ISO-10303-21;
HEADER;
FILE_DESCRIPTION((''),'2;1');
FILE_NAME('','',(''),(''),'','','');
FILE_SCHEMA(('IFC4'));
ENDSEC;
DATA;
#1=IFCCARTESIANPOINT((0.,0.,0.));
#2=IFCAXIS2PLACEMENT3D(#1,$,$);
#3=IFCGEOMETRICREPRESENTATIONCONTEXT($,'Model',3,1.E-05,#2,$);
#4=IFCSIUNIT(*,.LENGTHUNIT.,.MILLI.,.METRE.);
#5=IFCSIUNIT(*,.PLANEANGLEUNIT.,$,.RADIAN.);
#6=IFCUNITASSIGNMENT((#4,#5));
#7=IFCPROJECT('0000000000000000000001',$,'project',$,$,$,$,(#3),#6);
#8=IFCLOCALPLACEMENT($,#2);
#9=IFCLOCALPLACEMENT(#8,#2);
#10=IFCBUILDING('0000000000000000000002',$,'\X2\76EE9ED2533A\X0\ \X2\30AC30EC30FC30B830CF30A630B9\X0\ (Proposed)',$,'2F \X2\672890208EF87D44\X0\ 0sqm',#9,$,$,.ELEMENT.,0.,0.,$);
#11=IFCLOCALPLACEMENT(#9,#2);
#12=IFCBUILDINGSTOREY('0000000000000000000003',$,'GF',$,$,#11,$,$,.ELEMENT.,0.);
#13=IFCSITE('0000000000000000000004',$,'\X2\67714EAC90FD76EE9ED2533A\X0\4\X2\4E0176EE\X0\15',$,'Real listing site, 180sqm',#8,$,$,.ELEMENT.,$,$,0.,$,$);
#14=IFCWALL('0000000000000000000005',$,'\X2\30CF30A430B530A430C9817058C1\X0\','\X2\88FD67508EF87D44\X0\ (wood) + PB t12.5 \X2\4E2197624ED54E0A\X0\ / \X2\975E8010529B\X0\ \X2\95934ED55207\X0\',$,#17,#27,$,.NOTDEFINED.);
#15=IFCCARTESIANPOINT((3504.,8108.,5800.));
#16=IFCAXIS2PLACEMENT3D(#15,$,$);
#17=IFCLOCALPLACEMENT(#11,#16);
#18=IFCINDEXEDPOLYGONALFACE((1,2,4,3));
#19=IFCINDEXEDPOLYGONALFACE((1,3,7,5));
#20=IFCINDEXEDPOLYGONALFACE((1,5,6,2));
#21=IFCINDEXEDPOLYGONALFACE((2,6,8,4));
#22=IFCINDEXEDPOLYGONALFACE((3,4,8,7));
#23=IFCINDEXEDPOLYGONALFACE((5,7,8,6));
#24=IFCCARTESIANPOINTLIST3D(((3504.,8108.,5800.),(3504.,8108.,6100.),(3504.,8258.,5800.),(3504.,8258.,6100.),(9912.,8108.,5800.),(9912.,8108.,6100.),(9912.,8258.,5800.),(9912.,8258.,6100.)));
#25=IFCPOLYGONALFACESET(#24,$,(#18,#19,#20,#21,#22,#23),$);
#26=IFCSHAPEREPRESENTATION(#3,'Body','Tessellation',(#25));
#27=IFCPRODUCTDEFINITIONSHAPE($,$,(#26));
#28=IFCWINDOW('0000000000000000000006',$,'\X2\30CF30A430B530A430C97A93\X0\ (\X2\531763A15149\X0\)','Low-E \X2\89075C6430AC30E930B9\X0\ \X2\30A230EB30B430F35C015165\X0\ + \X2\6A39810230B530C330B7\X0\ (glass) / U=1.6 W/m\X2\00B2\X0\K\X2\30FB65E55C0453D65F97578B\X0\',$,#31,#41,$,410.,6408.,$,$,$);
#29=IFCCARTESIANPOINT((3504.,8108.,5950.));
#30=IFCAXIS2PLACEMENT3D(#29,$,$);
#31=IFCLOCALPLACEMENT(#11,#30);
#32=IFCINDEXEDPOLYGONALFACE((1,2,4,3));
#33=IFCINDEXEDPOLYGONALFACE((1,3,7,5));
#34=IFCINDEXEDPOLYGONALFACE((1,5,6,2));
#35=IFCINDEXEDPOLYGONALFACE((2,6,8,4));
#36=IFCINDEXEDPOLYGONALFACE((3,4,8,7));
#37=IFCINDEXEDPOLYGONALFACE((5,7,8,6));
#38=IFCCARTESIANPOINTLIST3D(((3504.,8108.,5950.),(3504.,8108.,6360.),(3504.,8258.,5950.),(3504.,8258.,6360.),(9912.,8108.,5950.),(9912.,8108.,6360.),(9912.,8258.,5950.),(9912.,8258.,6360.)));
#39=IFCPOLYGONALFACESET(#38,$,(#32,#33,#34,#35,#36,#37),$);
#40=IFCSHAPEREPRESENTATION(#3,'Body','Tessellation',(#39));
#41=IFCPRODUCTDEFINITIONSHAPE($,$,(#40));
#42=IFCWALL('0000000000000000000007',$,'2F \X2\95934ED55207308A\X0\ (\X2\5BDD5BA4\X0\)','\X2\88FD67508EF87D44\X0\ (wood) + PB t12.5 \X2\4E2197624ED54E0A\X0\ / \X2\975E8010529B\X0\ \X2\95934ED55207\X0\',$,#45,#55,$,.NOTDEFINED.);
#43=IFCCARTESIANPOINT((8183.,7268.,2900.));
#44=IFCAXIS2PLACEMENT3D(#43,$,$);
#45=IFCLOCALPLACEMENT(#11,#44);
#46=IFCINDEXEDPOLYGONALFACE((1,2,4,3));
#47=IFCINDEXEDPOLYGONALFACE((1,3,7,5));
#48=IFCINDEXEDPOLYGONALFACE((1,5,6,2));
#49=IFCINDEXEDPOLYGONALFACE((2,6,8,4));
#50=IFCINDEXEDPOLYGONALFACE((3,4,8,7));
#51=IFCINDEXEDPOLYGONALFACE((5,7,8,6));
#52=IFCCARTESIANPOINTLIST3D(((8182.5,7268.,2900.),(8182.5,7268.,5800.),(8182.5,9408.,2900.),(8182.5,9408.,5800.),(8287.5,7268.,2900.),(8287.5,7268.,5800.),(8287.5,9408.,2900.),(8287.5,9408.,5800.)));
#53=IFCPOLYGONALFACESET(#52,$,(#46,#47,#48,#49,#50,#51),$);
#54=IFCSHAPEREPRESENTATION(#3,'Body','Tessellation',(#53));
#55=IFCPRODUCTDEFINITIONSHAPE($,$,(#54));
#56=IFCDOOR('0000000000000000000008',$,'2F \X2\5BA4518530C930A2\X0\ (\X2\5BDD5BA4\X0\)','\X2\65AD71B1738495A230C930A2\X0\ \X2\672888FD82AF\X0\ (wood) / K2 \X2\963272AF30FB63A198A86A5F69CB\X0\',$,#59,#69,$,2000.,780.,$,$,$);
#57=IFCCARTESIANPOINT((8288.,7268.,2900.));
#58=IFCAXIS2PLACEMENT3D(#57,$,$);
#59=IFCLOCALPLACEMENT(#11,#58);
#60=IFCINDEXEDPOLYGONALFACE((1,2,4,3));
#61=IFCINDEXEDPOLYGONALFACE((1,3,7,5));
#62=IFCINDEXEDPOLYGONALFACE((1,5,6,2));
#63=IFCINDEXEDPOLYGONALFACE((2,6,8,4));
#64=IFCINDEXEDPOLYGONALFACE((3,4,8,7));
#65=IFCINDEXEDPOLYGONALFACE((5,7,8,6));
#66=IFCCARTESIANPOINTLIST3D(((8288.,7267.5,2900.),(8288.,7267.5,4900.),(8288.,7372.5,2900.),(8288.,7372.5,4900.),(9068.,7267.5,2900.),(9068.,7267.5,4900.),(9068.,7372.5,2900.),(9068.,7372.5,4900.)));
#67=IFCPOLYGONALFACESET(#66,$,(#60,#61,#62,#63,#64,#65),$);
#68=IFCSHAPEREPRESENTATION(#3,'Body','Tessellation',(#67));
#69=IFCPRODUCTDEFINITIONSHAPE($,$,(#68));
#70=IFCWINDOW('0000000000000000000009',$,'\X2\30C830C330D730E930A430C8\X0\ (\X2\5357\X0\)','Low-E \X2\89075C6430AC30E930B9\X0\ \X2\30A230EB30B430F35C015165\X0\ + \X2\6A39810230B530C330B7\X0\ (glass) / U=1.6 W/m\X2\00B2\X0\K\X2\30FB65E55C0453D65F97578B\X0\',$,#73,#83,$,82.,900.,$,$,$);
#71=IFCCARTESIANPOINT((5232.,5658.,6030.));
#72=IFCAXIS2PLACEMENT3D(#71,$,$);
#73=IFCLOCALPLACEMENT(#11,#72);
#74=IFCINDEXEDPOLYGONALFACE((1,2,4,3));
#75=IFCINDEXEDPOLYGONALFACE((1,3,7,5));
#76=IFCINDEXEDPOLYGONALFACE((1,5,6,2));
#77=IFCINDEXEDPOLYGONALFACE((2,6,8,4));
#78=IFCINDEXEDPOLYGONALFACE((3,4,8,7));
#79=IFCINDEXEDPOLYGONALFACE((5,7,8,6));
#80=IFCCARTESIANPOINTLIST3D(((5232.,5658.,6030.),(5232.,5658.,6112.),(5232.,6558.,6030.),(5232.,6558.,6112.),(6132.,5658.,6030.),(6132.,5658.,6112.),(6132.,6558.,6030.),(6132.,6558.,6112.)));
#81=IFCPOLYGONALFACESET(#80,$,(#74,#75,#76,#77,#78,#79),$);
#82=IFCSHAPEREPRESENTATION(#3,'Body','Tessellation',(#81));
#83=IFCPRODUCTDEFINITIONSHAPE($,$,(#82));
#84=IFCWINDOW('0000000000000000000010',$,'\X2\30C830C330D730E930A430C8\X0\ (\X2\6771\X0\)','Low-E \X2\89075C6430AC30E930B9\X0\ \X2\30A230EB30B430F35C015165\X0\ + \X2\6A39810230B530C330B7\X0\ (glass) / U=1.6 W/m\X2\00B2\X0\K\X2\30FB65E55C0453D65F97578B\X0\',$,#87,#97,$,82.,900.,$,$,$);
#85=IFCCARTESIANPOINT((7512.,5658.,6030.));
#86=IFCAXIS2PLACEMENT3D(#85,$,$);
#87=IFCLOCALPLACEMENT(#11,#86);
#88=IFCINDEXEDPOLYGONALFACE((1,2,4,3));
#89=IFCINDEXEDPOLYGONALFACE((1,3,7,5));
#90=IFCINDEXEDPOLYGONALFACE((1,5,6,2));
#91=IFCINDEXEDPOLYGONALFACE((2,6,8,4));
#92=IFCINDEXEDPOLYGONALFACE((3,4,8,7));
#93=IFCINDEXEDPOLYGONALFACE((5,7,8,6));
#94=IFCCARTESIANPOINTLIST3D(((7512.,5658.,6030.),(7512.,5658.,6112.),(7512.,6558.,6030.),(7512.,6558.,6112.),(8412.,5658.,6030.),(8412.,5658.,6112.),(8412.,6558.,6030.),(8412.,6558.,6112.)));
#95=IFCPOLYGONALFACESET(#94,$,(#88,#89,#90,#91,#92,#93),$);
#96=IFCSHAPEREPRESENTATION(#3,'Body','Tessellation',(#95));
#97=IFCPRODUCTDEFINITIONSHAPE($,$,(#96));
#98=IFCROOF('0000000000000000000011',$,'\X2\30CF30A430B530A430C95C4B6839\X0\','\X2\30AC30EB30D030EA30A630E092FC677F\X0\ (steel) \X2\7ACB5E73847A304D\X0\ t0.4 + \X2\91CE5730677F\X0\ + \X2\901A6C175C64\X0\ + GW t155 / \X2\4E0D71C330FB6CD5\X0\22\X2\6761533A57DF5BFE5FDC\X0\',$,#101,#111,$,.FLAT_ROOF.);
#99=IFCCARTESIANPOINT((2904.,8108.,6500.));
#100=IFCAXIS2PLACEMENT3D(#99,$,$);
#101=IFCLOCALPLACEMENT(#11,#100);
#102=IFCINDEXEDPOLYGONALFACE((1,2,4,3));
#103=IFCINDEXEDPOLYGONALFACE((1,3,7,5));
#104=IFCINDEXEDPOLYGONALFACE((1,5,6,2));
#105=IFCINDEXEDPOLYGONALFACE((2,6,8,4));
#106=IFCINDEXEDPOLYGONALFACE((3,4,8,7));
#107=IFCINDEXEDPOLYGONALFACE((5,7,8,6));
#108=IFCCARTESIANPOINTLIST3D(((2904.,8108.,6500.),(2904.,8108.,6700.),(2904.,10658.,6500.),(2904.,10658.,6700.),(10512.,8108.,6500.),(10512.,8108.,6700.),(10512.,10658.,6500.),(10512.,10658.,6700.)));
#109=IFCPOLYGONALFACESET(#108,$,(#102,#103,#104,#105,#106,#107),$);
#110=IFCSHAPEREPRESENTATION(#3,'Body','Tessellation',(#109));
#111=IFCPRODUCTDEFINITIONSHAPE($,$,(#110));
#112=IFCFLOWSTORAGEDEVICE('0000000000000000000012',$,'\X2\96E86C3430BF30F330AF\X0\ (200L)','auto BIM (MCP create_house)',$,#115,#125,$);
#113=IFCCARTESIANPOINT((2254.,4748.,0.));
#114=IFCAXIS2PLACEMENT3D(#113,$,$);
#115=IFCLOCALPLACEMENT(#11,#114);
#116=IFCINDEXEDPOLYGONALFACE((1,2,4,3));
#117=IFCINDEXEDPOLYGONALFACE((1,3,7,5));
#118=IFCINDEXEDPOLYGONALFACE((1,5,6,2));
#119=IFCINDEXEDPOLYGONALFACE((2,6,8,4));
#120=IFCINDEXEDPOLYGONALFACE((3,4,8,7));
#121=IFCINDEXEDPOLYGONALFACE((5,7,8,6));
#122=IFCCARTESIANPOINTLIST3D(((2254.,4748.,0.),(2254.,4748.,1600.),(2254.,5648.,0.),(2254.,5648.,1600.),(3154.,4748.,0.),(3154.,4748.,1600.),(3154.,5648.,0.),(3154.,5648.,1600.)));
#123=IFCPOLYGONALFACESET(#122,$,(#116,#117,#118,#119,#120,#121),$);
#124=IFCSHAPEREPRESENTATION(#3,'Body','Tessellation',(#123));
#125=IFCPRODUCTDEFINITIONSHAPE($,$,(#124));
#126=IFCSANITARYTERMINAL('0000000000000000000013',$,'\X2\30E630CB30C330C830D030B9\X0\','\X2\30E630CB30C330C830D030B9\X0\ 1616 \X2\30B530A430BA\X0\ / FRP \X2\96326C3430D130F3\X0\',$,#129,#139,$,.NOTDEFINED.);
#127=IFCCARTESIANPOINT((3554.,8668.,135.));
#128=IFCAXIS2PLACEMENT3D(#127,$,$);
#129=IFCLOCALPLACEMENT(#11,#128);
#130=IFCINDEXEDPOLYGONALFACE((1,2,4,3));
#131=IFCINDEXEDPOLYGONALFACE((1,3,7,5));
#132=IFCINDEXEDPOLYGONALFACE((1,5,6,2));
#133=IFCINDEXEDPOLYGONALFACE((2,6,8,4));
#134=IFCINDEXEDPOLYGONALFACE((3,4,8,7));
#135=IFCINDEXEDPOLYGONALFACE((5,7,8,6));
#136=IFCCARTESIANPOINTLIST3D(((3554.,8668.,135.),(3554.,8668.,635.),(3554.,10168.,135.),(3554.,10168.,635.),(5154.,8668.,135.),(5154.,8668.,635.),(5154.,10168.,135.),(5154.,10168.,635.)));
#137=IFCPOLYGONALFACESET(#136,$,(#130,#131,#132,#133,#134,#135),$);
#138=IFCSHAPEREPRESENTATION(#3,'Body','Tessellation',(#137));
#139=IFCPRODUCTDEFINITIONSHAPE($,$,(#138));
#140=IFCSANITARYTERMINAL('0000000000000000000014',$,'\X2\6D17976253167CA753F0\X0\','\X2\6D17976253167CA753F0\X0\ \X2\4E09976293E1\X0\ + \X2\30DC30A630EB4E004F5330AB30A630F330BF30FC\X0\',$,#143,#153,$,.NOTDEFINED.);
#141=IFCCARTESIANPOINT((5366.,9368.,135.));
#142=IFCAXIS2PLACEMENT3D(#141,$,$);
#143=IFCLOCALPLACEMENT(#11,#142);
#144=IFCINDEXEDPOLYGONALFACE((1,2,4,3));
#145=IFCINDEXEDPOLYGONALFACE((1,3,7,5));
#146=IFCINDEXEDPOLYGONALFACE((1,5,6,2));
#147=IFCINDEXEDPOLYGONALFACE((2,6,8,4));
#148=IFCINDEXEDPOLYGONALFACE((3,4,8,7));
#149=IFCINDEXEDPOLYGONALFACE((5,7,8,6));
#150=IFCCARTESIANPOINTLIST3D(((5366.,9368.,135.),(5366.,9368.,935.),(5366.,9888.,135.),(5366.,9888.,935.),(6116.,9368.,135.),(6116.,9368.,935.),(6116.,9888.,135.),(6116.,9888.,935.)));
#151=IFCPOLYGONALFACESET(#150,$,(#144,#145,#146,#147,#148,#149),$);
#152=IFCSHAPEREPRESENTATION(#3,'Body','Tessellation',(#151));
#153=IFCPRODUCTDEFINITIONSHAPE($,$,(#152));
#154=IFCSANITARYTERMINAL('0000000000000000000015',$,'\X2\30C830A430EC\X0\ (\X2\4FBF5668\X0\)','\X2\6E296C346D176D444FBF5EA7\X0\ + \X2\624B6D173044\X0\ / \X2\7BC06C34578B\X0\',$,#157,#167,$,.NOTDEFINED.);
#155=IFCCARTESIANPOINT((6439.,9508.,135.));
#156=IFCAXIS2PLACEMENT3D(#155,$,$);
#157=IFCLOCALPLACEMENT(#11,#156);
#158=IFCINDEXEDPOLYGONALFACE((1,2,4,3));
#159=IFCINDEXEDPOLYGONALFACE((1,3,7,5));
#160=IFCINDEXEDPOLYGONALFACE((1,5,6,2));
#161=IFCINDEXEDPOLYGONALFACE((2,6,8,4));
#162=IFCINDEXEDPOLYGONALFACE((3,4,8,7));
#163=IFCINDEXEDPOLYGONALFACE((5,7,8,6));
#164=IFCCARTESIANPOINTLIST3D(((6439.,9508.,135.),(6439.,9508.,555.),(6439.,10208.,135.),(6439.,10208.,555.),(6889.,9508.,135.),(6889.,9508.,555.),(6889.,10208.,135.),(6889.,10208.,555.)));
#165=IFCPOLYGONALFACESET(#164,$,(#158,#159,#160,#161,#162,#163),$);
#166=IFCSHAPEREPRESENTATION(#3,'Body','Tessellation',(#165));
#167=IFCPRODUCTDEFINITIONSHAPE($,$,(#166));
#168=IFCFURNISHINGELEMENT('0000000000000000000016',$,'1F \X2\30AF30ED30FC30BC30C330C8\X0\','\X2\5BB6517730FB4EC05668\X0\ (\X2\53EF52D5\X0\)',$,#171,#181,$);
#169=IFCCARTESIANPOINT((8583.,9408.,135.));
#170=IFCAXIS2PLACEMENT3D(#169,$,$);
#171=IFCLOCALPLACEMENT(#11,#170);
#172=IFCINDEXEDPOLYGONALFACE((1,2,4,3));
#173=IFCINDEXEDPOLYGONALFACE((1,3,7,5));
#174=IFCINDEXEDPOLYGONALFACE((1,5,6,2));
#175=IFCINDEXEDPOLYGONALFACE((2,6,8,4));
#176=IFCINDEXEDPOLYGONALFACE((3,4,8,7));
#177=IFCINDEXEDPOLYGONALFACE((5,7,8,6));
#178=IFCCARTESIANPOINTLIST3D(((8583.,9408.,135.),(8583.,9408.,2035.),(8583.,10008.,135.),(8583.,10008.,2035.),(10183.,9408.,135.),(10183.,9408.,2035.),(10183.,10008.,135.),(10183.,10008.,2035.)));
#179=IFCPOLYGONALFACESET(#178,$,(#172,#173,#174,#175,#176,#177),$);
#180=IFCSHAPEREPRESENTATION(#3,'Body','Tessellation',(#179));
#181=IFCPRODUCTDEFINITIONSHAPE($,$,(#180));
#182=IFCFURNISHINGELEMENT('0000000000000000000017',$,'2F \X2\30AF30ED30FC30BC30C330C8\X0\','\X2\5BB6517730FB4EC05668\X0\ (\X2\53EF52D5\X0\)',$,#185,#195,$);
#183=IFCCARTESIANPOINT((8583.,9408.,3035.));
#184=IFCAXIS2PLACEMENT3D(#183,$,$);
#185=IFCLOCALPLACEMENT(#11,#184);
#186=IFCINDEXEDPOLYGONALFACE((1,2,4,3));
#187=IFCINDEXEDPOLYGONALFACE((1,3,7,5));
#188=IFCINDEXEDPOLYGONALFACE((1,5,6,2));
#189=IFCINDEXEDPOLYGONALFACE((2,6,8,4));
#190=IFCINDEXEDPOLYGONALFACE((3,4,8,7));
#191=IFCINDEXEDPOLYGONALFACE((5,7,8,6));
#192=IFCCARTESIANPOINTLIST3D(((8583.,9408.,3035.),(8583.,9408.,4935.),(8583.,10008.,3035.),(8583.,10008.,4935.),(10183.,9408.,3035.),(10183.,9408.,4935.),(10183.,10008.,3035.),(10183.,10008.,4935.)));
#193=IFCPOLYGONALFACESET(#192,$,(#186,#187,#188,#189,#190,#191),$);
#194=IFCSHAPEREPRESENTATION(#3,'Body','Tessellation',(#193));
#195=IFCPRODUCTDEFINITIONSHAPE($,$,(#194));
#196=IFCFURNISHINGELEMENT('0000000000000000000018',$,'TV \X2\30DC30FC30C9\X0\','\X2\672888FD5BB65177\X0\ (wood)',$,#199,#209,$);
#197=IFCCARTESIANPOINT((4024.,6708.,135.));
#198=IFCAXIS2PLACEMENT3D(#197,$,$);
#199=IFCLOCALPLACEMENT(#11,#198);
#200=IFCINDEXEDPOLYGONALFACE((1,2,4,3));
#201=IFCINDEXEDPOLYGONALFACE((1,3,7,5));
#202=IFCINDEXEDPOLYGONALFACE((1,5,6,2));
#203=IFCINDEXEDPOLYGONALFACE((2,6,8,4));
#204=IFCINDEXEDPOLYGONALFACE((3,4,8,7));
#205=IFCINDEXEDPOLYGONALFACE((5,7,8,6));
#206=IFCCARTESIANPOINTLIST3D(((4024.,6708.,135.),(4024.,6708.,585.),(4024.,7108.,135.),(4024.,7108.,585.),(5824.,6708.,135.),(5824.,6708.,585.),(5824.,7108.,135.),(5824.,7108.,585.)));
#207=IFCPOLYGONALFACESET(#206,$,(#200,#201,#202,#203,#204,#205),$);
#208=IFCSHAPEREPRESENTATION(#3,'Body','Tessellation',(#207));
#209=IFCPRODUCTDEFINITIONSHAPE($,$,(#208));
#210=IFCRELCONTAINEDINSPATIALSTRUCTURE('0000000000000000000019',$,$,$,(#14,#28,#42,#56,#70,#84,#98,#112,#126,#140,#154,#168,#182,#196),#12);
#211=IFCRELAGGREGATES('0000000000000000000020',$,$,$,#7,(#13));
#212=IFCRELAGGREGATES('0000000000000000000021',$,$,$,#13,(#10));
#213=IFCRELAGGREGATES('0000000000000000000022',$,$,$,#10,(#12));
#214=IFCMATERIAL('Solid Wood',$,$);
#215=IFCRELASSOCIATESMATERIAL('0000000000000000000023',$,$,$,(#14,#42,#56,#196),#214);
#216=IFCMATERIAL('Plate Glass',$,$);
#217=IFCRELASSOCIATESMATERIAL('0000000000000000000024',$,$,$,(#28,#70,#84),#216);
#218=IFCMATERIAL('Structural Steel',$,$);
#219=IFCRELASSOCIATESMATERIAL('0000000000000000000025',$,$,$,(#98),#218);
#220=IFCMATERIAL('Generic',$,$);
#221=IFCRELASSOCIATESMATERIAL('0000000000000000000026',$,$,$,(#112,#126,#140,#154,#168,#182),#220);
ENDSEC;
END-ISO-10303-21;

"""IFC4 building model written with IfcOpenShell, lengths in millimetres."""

from ifc_helpers import new_model, si_unit, frame, frame_2d, origin, place, context, project, spatial, rectangle, extrude, material, element, fill, save


model = new_model("IFC4")

# Units and contexts
model_context = context("Model", 3, precision=1e-05, world=origin())
ifc_project = project(units=[si_unit("LENGTHUNIT", "METRE", prefix="MILLI"), si_unit("PLANEANGLEUNIT", "RADIAN")], contexts=[model_context])

# Site, building, storey
site_placement = place(None, origin())
site = spatial("IfcSite", under=ifc_project, at=site_placement, Name="東京都目黒区4丁目15", ObjectType="Real listing site, 180sqm", CompositionType="ELEMENT", RefElevation=0.0)
building_placement = place(site_placement, origin())
building = spatial("IfcBuilding", under=site, at=building_placement, Name="目黒区 ガレージハウス (Proposed)", ObjectType="2F 木造軸組 0sqm", CompositionType="ELEMENT", ElevationOfRefHeight=0.0, ElevationOfTerrain=0.0)
storey_placement = place(building_placement, origin())
storey = spatial("IfcBuildingStorey", under=building, at=storey_placement, Name="GF", CompositionType="ELEMENT", Elevation=0.0)

# Shared definitions
ifc_material_1 = material(Name="Solid Wood")
ifc_material_2 = material(Name="Plate Glass")

# Wall, opening, window
wall_1_placement = place(storey_placement, frame((3504.0, 8108.0, 5800.0)))
wall_1 = element("IfcWall", 1, at=wall_1_placement, inside=storey, material=ifc_material_1, Name="ハイサイド腰壁", Description="製材軸組 (wood) + PB t12.5 両面仕上 / 非耐力 間仕切", PredefinedType="NOTDEFINED", context=model_context, shape_type="SweptSolid", body=[
    extrude(rectangle(XDim=6408.0, YDim=150.0, at=frame_2d((3204.0, 75.0))), frame((3504.0, 8108.0, 5800.0)), (0.0, 0.0, 1.0), 700.0),
])
opening_1_placement = place(storey_placement, frame((3504.0, 8108.0, 5950.0)))
opening_1 = element("IfcOpeningElement", 2, at=opening_1_placement, cuts=wall_1, PredefinedType="NOTDEFINED", context=model_context, shape_type="SweptSolid", body=[
    extrude(rectangle(XDim=6408.0, YDim=150.0, at=frame_2d((3204.0, 75.0))), frame((3504.0, 8108.0, 5950.0)), (0.0, 0.0, 1.0), 410.0),
])
window_1_placement = place(storey_placement, frame((3504.0, 8108.0, 5950.0)))
window_1 = element("IfcWindow", 3, at=window_1_placement, inside=storey, material=ifc_material_2, Name="ハイサイド窓 (北採光)", Description="Low-E 複層ガラス アルゴン封入 + 樹脂サッシ (glass) / U=1.6 W/m²K・日射取得型", OverallHeight=410.0, OverallWidth=6408.0, context=model_context, shape_type="SweptSolid", body=[
    extrude(rectangle(XDim=6408.0, YDim=150.0, at=frame_2d((3204.0, 75.0))), frame((3504.0, 8108.0, 5950.0)), (0.0, 0.0, 1.0), 410.0),
])
fill(opening_1, window_1)

# Wall
wall_2_placement = place(storey_placement, frame((8183.0, 7268.0, 2900.0)))
element("IfcWall", 4, at=wall_2_placement, inside=storey, material=ifc_material_1, Name="2F 間仕切り (寝室)", Description="製材軸組 (wood) + PB t12.5 両面仕上 / 非耐力 間仕切", PredefinedType="NOTDEFINED", context=model_context, shape_type="SweptSolid", body=[
    extrude(rectangle(XDim=105.0, YDim=2140.0, at=frame_2d((52.0, 1070.0))), frame((8183.0, 7268.0, 2900.0)), (0.0, 0.0, 1.0), 2900.0),
])

# Door
door_1_placement = place(storey_placement, frame((8288.0, 7268.0, 2900.0)))
element("IfcDoor", 5, at=door_1_placement, inside=storey, material=ifc_material_1, Name="2F 室内ドア (寝室)", Description="断熱玄関ドア 木製芯 (wood) / K2 防犯・採風機構", OverallHeight=2000.0, OverallWidth=780.0, context=model_context, shape_type="SweptSolid", body=[
    extrude(rectangle(XDim=780.0, YDim=105.0, at=frame_2d((390.0, 52.0))), frame((8288.0, 7268.0, 2900.0)), (0.0, 0.0, 1.0), 2000.0),
])

# Windows
window_2_placement = place(storey_placement, frame((5232.0, 5658.0, 6030.0)))
element("IfcWindow", 6, at=window_2_placement, inside=storey, material=ifc_material_2, Name="トップライト (南)", Description="Low-E 複層ガラス アルゴン封入 + 樹脂サッシ (glass) / U=1.6 W/m²K・日射取得型", OverallHeight=82.0, OverallWidth=900.0, context=model_context, shape_type="SweptSolid", body=[
    extrude(rectangle(XDim=900.0, YDim=900.0, at=frame_2d((450.0, 450.0))), frame((5232.0, 5658.0, 6030.0)), (0.0, 0.0, 1.0), 82.0),
])
window_3_placement = place(storey_placement, frame((7512.0, 5658.0, 6030.0)))
element("IfcWindow", 7, at=window_3_placement, inside=storey, material=ifc_material_2, Name="トップライト (東)", Description="Low-E 複層ガラス アルゴン封入 + 樹脂サッシ (glass) / U=1.6 W/m²K・日射取得型", OverallHeight=82.0, OverallWidth=900.0, context=model_context, shape_type="SweptSolid", body=[
    extrude(rectangle(XDim=900.0, YDim=900.0, at=frame_2d((450.0, 450.0))), frame((7512.0, 5658.0, 6030.0)), (0.0, 0.0, 1.0), 82.0),
])

# Roof
ifc_material_3 = material(Name="Structural Steel")
roof_placement = place(storey_placement, frame((2904.0, 8108.0, 6500.0)))
element("IfcRoof", 8, at=roof_placement, inside=storey, material=ifc_material_3, Name="ハイサイド屋根", Description="ガルバリウム鋼板 (steel) 立平葺き t0.4 + 野地板 + 通気層 + GW t155 / 不燃・法22条区域対応", PredefinedType="FLAT_ROOF", context=model_context, shape_type="SweptSolid", body=[
    extrude(rectangle(XDim=7608.0, YDim=2550.0, at=frame_2d((3804.0, 1275.0))), frame((2904.0, 8108.0, 6500.0)), (0.0, 0.0, 1.0), 200.0),
])

# Flow storage device
ifc_material_4 = material(Name="Generic")
flow_storage_device_placement = place(storey_placement, frame((2254.0, 4748.0, 0.0)))
element("IfcFlowStorageDevice", 9, at=flow_storage_device_placement, inside=storey, material=ifc_material_4, Name="雨水タンク (200L)", Description="auto BIM (MCP create_house)", context=model_context, shape_type="SweptSolid", body=[
    extrude(rectangle(XDim=900.0, YDim=900.0, at=frame_2d((450.0, 450.0))), frame((2254.0, 4748.0, 0.0)), (0.0, 0.0, 1.0), 1600.0),
])

# Sanitary terminals
sanitary_terminal_1_placement = place(storey_placement, frame((3554.0, 8668.0, 135.0)))
element("IfcSanitaryTerminal", 10, at=sanitary_terminal_1_placement, inside=storey, material=ifc_material_4, Name="ユニットバス", Description="ユニットバス 1616 サイズ / FRP 防水パン", PredefinedType="NOTDEFINED", context=model_context, shape_type="SweptSolid", body=[
    extrude(rectangle(XDim=1600.0, YDim=1500.0, at=frame_2d((800.0, 750.0))), frame((3554.0, 8668.0, 135.0)), (0.0, 0.0, 1.0), 500.0),
])
sanitary_terminal_2_placement = place(storey_placement, frame((5366.0, 9368.0, 135.0)))
element("IfcSanitaryTerminal", 11, at=sanitary_terminal_2_placement, inside=storey, material=ifc_material_4, Name="洗面化粧台", Description="洗面化粧台 三面鏡 + ボウル一体カウンター", PredefinedType="NOTDEFINED", context=model_context, shape_type="SweptSolid", body=[
    extrude(rectangle(XDim=750.0, YDim=520.0, at=frame_2d((375.0, 260.0))), frame((5366.0, 9368.0, 135.0)), (0.0, 0.0, 1.0), 800.0),
])
sanitary_terminal_3_placement = place(storey_placement, frame((6439.0, 9508.0, 135.0)))
element("IfcSanitaryTerminal", 12, at=sanitary_terminal_3_placement, inside=storey, material=ifc_material_4, Name="トイレ (便器)", Description="温水洗浄便座 + 手洗い / 節水型", PredefinedType="NOTDEFINED", context=model_context, shape_type="SweptSolid", body=[
    extrude(rectangle(XDim=450.0, YDim=700.0, at=frame_2d((225.0, 350.0))), frame((6439.0, 9508.0, 135.0)), (0.0, 0.0, 1.0), 420.0),
])

# Furnishing elements
furnishing_1_placement = place(storey_placement, frame((8583.0, 9408.0, 135.0)))
element("IfcFurnishingElement", 13, at=furnishing_1_placement, inside=storey, material=ifc_material_4, Name="1F クローゼット", Description="家具・什器 (可動)", context=model_context, shape_type="SweptSolid", body=[
    extrude(rectangle(XDim=1600.0, YDim=600.0, at=frame_2d((800.0, 300.0))), frame((8583.0, 9408.0, 135.0)), (0.0, 0.0, 1.0), 1900.0),
])
furnishing_2_placement = place(storey_placement, frame((8583.0, 9408.0, 3035.0)))
element("IfcFurnishingElement", 14, at=furnishing_2_placement, inside=storey, material=ifc_material_4, Name="2F クローゼット", Description="家具・什器 (可動)", context=model_context, shape_type="SweptSolid", body=[
    extrude(rectangle(XDim=1600.0, YDim=600.0, at=frame_2d((800.0, 300.0))), frame((8583.0, 9408.0, 3035.0)), (0.0, 0.0, 1.0), 1900.0),
])
furnishing_3_placement = place(storey_placement, frame((4024.0, 6708.0, 135.0)))
element("IfcFurnishingElement", 15, at=furnishing_3_placement, inside=storey, material=ifc_material_1, Name="TV ボード", Description="木製家具 (wood)", context=model_context, shape_type="SweptSolid", body=[
    extrude(rectangle(XDim=1800.0, YDim=400.0, at=frame_2d((900.0, 200.0))), frame((4024.0, 6708.0, 135.0)), (0.0, 0.0, 1.0), 450.0),
])

save(model, "model.ifc")
